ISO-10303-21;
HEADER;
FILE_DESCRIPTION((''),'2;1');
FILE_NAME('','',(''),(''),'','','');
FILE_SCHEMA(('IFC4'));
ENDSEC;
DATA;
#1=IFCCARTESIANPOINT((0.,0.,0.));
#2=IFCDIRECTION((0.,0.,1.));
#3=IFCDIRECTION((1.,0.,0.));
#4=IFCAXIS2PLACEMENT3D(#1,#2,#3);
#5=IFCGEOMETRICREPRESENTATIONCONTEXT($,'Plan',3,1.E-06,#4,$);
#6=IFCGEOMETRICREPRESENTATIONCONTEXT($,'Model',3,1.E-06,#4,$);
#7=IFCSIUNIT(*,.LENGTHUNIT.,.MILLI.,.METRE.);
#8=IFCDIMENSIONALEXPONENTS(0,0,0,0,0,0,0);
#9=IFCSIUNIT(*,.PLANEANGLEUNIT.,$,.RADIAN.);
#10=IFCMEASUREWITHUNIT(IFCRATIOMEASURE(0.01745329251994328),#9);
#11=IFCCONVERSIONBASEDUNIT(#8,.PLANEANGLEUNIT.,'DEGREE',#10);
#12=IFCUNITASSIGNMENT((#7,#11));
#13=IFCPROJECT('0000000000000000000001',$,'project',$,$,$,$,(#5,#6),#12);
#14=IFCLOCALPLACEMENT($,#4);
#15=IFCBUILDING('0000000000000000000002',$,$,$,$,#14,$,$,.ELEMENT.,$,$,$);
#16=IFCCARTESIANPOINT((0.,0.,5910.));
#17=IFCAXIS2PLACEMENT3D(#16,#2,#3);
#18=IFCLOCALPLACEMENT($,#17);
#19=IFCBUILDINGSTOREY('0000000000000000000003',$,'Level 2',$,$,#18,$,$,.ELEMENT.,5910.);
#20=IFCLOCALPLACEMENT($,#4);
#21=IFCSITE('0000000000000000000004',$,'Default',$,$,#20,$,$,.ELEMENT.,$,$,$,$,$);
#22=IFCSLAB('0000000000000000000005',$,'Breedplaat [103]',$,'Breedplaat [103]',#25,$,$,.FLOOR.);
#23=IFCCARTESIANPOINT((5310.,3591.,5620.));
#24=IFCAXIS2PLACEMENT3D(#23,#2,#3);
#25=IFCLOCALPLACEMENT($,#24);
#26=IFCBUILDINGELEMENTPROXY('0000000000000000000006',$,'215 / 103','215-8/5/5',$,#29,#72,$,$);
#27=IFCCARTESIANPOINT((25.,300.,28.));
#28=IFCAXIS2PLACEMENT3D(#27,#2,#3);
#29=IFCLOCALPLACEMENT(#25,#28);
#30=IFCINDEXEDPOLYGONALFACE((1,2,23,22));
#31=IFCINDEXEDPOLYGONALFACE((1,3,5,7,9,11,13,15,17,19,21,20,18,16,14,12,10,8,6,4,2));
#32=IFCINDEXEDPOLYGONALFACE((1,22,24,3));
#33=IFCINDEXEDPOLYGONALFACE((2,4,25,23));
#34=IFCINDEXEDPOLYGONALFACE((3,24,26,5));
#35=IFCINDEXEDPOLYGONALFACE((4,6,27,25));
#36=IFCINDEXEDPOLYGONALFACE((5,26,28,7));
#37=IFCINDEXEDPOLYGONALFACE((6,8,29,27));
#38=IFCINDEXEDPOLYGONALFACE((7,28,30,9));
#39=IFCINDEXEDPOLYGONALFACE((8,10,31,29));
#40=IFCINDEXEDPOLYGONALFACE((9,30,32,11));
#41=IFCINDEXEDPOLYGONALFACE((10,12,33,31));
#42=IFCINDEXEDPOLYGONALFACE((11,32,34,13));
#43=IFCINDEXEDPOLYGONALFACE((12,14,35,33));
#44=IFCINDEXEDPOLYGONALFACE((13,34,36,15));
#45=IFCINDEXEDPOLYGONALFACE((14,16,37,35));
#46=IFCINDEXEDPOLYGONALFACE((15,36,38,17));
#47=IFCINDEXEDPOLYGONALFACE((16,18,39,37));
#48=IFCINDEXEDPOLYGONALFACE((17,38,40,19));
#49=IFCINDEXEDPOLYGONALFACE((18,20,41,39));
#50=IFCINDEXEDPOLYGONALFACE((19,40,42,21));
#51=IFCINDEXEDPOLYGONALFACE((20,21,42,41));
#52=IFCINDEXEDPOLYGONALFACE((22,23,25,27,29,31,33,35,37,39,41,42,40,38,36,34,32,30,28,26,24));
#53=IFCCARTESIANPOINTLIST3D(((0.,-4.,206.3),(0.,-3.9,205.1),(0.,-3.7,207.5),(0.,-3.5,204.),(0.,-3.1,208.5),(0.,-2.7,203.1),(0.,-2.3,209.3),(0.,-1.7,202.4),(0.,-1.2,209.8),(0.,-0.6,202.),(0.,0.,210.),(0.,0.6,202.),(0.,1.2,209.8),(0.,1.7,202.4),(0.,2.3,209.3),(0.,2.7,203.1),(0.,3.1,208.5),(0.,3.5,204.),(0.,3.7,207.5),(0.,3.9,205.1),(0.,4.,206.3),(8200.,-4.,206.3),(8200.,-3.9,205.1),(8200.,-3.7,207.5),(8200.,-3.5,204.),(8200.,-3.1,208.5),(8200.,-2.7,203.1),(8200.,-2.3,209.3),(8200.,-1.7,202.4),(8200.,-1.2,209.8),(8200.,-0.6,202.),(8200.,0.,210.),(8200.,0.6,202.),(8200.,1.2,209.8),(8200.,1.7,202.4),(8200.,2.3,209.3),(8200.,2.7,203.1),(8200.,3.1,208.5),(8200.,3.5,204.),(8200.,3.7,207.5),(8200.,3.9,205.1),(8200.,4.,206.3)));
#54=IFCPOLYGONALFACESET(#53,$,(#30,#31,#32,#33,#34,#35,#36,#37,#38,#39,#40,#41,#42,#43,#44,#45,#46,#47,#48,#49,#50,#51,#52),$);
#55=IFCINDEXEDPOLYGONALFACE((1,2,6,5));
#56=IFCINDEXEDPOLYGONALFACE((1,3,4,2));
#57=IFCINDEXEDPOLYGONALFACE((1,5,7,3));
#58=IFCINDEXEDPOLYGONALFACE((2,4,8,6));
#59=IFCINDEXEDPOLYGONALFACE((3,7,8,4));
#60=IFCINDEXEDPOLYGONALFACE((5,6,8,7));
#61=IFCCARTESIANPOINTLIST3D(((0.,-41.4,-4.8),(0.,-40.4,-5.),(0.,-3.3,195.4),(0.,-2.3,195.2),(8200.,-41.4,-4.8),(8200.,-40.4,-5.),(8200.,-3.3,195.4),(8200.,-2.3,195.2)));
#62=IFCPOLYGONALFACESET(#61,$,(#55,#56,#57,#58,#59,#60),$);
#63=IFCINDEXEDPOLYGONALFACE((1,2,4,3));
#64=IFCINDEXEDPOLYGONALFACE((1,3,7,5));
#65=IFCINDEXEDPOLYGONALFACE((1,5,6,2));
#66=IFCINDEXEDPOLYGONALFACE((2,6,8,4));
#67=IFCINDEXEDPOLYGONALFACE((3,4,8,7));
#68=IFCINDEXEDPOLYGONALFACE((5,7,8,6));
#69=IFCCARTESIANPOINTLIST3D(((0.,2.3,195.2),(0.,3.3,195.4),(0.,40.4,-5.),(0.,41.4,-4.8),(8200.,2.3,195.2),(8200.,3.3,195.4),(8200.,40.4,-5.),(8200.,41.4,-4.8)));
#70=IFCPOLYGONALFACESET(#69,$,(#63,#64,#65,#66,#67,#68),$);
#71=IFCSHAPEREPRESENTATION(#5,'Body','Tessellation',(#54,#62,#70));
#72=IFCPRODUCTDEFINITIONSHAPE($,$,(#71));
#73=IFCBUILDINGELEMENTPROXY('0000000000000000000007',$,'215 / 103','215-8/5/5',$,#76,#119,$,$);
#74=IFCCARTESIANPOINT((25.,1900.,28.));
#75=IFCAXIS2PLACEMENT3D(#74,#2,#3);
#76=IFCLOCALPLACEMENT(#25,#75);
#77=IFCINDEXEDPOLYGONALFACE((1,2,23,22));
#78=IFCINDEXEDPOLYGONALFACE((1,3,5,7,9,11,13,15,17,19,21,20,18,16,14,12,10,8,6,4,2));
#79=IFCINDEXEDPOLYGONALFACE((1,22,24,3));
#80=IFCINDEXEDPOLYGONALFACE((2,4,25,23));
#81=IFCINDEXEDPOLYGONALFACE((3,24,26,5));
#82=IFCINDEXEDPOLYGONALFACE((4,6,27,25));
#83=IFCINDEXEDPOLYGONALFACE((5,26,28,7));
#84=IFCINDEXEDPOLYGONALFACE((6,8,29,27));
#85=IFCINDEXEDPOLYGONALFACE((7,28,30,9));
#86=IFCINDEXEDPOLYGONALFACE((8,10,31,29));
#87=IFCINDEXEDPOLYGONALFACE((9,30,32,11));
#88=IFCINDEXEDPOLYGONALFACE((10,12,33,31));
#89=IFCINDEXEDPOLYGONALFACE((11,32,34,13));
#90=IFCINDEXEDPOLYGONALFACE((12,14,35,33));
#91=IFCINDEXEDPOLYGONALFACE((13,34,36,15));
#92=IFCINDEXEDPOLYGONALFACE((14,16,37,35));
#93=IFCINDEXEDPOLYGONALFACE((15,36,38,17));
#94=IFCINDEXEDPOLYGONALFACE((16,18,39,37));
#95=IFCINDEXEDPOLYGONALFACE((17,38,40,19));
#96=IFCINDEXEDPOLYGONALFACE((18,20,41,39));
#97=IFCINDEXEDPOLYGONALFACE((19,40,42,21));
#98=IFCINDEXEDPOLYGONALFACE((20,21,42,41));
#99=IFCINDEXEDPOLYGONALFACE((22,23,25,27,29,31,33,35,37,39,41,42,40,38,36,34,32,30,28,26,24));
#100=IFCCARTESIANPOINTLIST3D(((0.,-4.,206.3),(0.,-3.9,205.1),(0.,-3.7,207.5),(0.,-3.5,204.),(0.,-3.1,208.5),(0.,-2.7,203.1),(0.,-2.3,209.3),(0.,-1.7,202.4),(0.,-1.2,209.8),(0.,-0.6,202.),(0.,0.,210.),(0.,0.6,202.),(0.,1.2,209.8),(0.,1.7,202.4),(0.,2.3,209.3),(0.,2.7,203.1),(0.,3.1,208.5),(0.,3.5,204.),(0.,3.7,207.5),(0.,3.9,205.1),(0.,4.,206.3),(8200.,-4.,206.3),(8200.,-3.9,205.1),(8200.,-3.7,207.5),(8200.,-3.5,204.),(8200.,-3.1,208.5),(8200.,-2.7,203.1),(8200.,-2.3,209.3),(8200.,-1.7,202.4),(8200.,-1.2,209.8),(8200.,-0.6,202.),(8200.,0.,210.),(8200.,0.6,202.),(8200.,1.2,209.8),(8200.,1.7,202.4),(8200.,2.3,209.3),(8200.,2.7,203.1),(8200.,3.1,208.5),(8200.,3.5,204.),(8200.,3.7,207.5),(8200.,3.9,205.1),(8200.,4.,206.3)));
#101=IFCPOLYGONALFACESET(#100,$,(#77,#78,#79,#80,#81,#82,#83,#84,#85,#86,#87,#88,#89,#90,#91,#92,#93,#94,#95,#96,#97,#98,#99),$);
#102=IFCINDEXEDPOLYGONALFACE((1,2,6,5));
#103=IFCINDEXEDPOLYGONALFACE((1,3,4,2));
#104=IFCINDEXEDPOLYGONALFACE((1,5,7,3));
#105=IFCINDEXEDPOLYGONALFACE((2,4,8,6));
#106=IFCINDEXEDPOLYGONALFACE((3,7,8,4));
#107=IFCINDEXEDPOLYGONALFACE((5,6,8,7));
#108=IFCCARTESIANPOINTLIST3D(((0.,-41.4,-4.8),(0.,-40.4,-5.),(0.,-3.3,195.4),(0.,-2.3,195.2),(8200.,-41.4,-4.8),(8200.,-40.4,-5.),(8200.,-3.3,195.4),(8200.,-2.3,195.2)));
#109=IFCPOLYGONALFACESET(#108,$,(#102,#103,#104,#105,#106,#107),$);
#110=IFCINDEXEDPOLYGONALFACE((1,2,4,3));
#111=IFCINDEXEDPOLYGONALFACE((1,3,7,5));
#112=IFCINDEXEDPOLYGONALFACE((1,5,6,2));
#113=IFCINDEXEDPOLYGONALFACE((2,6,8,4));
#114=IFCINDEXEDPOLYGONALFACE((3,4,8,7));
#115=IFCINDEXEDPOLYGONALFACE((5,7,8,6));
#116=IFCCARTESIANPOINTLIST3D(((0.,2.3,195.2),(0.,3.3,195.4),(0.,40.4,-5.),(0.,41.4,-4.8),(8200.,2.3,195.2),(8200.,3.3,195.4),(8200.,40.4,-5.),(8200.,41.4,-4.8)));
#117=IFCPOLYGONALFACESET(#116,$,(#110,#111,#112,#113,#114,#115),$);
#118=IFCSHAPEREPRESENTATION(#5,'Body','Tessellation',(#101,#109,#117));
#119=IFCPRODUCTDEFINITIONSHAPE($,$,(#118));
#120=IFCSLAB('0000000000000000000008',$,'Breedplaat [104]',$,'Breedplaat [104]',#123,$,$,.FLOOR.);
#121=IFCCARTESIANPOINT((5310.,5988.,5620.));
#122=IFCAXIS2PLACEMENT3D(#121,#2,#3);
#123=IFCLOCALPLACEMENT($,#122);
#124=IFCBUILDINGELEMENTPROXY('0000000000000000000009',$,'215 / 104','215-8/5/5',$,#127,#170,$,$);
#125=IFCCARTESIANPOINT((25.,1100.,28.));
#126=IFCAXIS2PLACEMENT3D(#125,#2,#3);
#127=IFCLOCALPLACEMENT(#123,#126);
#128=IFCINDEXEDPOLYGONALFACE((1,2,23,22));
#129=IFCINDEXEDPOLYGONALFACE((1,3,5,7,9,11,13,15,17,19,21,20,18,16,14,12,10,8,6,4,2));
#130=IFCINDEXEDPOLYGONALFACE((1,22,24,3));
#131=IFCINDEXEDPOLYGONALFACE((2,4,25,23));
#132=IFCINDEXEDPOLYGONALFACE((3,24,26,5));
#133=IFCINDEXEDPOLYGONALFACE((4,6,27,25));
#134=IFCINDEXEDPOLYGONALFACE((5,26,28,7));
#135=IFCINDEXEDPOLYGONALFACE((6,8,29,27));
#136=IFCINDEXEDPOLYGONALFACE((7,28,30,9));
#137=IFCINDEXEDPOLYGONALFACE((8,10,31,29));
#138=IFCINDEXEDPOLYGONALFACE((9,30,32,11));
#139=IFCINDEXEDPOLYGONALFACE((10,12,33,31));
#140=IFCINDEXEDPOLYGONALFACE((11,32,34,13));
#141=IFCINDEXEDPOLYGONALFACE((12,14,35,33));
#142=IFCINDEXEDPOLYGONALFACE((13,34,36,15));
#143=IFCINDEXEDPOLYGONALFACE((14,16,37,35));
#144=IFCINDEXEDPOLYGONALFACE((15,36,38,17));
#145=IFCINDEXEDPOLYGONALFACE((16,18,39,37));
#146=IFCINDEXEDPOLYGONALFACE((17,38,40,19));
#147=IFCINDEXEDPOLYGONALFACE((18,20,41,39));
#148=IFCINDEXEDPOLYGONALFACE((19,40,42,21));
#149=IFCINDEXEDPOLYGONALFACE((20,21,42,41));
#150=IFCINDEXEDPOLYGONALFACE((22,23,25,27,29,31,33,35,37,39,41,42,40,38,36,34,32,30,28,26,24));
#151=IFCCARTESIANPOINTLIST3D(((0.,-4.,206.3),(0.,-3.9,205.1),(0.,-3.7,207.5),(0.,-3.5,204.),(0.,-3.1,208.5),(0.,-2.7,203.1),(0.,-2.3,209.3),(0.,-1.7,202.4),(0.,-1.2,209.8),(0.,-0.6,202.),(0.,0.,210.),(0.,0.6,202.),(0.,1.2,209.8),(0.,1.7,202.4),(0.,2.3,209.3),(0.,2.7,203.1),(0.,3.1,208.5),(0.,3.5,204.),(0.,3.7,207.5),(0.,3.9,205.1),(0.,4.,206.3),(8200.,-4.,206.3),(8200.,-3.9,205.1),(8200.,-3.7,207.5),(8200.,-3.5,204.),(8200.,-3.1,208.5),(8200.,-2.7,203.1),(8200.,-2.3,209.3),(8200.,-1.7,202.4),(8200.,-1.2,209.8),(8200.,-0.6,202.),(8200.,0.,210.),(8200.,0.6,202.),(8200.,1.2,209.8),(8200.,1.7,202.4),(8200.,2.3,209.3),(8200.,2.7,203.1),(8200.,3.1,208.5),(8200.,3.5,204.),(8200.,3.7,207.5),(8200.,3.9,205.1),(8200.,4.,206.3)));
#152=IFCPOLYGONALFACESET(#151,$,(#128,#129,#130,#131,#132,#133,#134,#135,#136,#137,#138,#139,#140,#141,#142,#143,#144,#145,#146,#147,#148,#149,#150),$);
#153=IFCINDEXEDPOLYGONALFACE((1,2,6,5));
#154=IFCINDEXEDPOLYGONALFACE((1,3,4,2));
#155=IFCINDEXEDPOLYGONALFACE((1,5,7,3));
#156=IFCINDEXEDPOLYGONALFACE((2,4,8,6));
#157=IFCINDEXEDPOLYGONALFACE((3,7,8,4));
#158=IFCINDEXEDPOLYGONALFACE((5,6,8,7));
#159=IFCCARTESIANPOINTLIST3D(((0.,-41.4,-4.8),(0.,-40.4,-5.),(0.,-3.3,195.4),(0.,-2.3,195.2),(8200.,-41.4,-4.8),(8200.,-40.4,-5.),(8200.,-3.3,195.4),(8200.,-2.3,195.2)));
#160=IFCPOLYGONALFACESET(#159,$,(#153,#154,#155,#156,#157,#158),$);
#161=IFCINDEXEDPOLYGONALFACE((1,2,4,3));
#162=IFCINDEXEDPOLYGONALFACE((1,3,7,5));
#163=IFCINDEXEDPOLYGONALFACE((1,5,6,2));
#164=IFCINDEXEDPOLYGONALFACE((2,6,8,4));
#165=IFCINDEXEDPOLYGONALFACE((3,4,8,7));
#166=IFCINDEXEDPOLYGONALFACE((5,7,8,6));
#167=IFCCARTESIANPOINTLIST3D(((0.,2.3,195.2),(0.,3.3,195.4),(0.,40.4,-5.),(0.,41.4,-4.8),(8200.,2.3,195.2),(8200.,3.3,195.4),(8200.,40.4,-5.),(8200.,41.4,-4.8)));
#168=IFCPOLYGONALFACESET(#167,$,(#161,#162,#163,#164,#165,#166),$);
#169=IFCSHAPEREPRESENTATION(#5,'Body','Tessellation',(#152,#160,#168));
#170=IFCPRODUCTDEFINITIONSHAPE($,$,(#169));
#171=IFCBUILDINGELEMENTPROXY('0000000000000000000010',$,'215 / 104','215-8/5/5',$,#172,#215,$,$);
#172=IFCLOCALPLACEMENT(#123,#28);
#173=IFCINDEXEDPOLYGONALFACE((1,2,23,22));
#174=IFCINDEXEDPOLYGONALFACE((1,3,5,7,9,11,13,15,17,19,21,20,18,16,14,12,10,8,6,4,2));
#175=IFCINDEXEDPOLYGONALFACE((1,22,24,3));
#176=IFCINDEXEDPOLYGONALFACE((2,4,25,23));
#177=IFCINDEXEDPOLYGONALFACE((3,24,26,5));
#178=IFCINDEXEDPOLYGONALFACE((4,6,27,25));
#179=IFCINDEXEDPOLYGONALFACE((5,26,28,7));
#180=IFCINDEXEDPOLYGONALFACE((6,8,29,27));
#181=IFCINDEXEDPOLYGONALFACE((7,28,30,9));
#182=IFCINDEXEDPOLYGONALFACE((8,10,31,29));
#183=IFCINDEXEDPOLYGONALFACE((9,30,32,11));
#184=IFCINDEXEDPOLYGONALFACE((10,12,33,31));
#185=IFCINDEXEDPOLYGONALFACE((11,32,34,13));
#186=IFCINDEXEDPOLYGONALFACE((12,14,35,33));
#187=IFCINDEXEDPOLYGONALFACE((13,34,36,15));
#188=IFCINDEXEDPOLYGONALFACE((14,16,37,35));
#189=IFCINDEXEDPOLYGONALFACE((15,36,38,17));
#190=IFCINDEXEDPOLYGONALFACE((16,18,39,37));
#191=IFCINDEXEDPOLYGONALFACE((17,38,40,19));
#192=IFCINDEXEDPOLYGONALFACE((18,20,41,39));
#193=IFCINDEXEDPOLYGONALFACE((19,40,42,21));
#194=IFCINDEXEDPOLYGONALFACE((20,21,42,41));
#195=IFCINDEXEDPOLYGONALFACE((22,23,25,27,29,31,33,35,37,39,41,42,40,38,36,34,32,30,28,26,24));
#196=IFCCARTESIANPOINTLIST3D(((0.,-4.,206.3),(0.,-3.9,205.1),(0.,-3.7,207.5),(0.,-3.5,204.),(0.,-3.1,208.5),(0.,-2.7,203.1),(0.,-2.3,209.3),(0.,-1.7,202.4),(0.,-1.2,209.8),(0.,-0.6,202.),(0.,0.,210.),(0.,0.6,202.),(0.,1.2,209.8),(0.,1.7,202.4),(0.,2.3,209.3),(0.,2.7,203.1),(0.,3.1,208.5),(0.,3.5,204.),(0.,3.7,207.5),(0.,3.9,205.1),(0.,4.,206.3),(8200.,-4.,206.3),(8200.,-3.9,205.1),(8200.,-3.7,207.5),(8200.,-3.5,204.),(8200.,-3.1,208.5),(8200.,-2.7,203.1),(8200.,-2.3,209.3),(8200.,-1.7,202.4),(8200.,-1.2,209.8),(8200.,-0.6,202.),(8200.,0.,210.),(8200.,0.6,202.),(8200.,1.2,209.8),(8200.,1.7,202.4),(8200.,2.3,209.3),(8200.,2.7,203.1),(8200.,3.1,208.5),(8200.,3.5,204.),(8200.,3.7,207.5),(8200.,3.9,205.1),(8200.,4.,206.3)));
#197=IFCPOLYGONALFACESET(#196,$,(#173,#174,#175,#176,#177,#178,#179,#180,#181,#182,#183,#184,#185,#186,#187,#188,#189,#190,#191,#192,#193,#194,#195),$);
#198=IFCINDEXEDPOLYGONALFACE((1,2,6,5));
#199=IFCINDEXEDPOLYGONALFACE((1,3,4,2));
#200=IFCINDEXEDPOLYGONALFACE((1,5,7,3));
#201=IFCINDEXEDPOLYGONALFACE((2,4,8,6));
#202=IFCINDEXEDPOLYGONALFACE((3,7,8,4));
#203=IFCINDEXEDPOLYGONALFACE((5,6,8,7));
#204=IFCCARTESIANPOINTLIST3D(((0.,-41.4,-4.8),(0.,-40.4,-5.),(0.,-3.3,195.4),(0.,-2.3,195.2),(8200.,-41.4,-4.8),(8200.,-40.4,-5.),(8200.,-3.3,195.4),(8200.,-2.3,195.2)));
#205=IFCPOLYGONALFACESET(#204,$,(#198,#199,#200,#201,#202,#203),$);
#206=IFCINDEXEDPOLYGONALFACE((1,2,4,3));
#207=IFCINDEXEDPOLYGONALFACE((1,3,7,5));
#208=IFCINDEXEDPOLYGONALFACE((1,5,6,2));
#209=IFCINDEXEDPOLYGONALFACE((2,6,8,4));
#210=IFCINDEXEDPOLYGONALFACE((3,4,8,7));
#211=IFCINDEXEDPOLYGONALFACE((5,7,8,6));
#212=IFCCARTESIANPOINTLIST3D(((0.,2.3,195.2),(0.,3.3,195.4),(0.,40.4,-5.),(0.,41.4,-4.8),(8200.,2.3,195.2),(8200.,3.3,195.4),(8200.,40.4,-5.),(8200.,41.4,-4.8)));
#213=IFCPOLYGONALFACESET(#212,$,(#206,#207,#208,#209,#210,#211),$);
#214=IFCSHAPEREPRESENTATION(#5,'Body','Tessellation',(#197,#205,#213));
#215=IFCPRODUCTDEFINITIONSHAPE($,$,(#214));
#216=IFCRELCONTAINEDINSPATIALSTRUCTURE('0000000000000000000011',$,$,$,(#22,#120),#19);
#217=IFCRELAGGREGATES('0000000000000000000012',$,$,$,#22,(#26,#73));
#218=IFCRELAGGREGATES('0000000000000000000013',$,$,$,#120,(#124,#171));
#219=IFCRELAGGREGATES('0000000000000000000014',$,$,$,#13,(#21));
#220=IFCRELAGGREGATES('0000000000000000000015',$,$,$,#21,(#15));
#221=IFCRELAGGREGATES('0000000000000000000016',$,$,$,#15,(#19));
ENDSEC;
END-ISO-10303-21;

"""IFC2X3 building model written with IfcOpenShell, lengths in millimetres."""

from ifc_helpers import new_model, entity, si_unit, converted_unit, frame, origin_with_axes, origin_2d_with_axis, place, context, project, spatial, rectangle, circle, extrude, element, aggregate, save


model = new_model("IFC2X3")

# Units and contexts
plan_context = context("Plan", 3, precision=1e-06, world=origin_with_axes())
model_context = context("Model", 3, precision=1e-06, world=origin_with_axes())
ifc_project = project(units=[si_unit("LENGTHUNIT", "METRE", prefix="MILLI"), converted_unit("PLANEANGLEUNIT", "DEGREE", entity("IfcRatioMeasure", 0.01745329251994328), si_unit("PLANEANGLEUNIT", "RADIAN"), dimensions=[0, 0, 0, 0, 0, 0, 0])], contexts=[plan_context, model_context])

# Site, building, storey
site_placement = place(None, origin_with_axes())
site = spatial("IfcSite", under=ifc_project, at=site_placement, Name="Default", CompositionType="ELEMENT")
building_placement = place(None, origin_with_axes())
building = spatial("IfcBuilding", under=site, at=building_placement, CompositionType="ELEMENT")
storey_placement = place(None, frame((0.0, 0.0, 5910.0), z_axis=(0.0, 0.0, 1.0), x_axis=(1.0, 0.0, 0.0)))
storey = spatial("IfcBuildingStorey", under=building, at=storey_placement, Name="Level 2", CompositionType="ELEMENT", Elevation=5910.0)

# Slabs, building element proxies
slab_1_placement = place(None, frame((5310.0, 3591.0, 5620.0), z_axis=(0.0, 0.0, 1.0), x_axis=(1.0, 0.0, 0.0)))
slab_1 = element("IfcSlab", 1, at=slab_1_placement, inside=storey, Name="Breedplaat [103]", ObjectType="Breedplaat [103]", PredefinedType="FLOOR")
proxy_1_placement = place(slab_1_placement, frame((25.0, 300.0, 28.0), z_axis=(0.0, 0.0, 1.0), x_axis=(1.0, 0.0, 0.0)))
proxy_1 = element("IfcBuildingElementProxy", 2, at=proxy_1_placement, Name="215 / 103", Description="215-8/5/5", context=plan_context, shape_type="SweptSolid", body=[
    extrude(circle(Radius=4.0, at=origin_2d_with_axis()), frame((0.0, 0.0, 206.0), z_axis=(1.0, 0.0, 0.0), x_axis=(0.0, 0.0, 1.0)), (0.0, 0.0, 1.0), 8200.0),
    extrude(rectangle(XDim=203.8, YDim=1.0, at=origin_2d_with_axis()), frame((0.0, -21.9, 95.2), z_axis=(1.0, 0.0, 0.0), x_axis=(0.0, 0.187112, 0.982339)), (0.0, 0.0, 1.0), 8200.0),
    extrude(rectangle(XDim=203.8, YDim=1.0, at=origin_2d_with_axis()), frame((0.0, 21.9, 95.2), z_axis=(1.0, 0.0, 0.0), x_axis=(0.0, -0.187112, 0.982339)), (0.0, 0.0, 1.0), 8200.0),
])
proxy_2_placement = place(slab_1_placement, frame((25.0, 1900.0, 28.0), z_axis=(0.0, 0.0, 1.0), x_axis=(1.0, 0.0, 0.0)))
proxy_2 = element("IfcBuildingElementProxy", 3, at=proxy_2_placement, Name="215 / 103", Description="215-8/5/5", context=plan_context, shape_type="SweptSolid", body=[
    extrude(circle(Radius=4.0, at=origin_2d_with_axis()), frame((0.0, 0.0, 206.0), z_axis=(1.0, 0.0, 0.0), x_axis=(0.0, 0.0, 1.0)), (0.0, 0.0, 1.0), 8200.0),
    extrude(rectangle(XDim=203.8, YDim=1.0, at=origin_2d_with_axis()), frame((0.0, -21.9, 95.2), z_axis=(1.0, 0.0, 0.0), x_axis=(0.0, 0.187112, 0.982339)), (0.0, 0.0, 1.0), 8200.0),
    extrude(rectangle(XDim=203.8, YDim=1.0, at=origin_2d_with_axis()), frame((0.0, 21.9, 95.2), z_axis=(1.0, 0.0, 0.0), x_axis=(0.0, -0.187112, 0.982339)), (0.0, 0.0, 1.0), 8200.0),
])
aggregate(slab_1, [proxy_1, proxy_2])
slab_2_placement = place(None, frame((5310.0, 5988.0, 5620.0), z_axis=(0.0, 0.0, 1.0), x_axis=(1.0, 0.0, 0.0)))
slab_2 = element("IfcSlab", 4, at=slab_2_placement, inside=storey, Name="Breedplaat [104]", ObjectType="Breedplaat [104]", PredefinedType="FLOOR")
proxy_3_placement = place(slab_2_placement, frame((25.0, 1100.0, 28.0), z_axis=(0.0, 0.0, 1.0), x_axis=(1.0, 0.0, 0.0)))
proxy_3 = element("IfcBuildingElementProxy", 5, at=proxy_3_placement, Name="215 / 104", Description="215-8/5/5", context=plan_context, shape_type="SweptSolid", body=[
    extrude(circle(Radius=4.0, at=origin_2d_with_axis()), frame((0.0, 0.0, 206.0), z_axis=(1.0, 0.0, 0.0), x_axis=(0.0, 0.0, 1.0)), (0.0, 0.0, 1.0), 8200.0),
    extrude(rectangle(XDim=203.8, YDim=1.0, at=origin_2d_with_axis()), frame((0.0, -21.9, 95.2), z_axis=(1.0, 0.0, 0.0), x_axis=(0.0, 0.187112, 0.982339)), (0.0, 0.0, 1.0), 8200.0),
    extrude(rectangle(XDim=203.8, YDim=1.0, at=origin_2d_with_axis()), frame((0.0, 21.9, 95.2), z_axis=(1.0, 0.0, 0.0), x_axis=(0.0, -0.187112, 0.982339)), (0.0, 0.0, 1.0), 8200.0),
])
proxy_4_placement = place(slab_2_placement, frame((25.0, 300.0, 28.0), z_axis=(0.0, 0.0, 1.0), x_axis=(1.0, 0.0, 0.0)))
proxy_4 = element("IfcBuildingElementProxy", 6, at=proxy_4_placement, Name="215 / 104", Description="215-8/5/5", context=plan_context, shape_type="SweptSolid", body=[
    extrude(circle(Radius=4.0, at=origin_2d_with_axis()), frame((0.0, 0.0, 206.0), z_axis=(1.0, 0.0, 0.0), x_axis=(0.0, 0.0, 1.0)), (0.0, 0.0, 1.0), 8200.0),
    extrude(rectangle(XDim=203.8, YDim=1.0, at=origin_2d_with_axis()), frame((0.0, -21.9, 95.2), z_axis=(1.0, 0.0, 0.0), x_axis=(0.0, 0.187112, 0.982339)), (0.0, 0.0, 1.0), 8200.0),
    extrude(rectangle(XDim=203.8, YDim=1.0, at=origin_2d_with_axis()), frame((0.0, 21.9, 95.2), z_axis=(1.0, 0.0, 0.0), x_axis=(0.0, -0.187112, 0.982339)), (0.0, 0.0, 1.0), 8200.0),
])
aggregate(slab_2, [proxy_3, proxy_4])

save(model, "model.ifc")
